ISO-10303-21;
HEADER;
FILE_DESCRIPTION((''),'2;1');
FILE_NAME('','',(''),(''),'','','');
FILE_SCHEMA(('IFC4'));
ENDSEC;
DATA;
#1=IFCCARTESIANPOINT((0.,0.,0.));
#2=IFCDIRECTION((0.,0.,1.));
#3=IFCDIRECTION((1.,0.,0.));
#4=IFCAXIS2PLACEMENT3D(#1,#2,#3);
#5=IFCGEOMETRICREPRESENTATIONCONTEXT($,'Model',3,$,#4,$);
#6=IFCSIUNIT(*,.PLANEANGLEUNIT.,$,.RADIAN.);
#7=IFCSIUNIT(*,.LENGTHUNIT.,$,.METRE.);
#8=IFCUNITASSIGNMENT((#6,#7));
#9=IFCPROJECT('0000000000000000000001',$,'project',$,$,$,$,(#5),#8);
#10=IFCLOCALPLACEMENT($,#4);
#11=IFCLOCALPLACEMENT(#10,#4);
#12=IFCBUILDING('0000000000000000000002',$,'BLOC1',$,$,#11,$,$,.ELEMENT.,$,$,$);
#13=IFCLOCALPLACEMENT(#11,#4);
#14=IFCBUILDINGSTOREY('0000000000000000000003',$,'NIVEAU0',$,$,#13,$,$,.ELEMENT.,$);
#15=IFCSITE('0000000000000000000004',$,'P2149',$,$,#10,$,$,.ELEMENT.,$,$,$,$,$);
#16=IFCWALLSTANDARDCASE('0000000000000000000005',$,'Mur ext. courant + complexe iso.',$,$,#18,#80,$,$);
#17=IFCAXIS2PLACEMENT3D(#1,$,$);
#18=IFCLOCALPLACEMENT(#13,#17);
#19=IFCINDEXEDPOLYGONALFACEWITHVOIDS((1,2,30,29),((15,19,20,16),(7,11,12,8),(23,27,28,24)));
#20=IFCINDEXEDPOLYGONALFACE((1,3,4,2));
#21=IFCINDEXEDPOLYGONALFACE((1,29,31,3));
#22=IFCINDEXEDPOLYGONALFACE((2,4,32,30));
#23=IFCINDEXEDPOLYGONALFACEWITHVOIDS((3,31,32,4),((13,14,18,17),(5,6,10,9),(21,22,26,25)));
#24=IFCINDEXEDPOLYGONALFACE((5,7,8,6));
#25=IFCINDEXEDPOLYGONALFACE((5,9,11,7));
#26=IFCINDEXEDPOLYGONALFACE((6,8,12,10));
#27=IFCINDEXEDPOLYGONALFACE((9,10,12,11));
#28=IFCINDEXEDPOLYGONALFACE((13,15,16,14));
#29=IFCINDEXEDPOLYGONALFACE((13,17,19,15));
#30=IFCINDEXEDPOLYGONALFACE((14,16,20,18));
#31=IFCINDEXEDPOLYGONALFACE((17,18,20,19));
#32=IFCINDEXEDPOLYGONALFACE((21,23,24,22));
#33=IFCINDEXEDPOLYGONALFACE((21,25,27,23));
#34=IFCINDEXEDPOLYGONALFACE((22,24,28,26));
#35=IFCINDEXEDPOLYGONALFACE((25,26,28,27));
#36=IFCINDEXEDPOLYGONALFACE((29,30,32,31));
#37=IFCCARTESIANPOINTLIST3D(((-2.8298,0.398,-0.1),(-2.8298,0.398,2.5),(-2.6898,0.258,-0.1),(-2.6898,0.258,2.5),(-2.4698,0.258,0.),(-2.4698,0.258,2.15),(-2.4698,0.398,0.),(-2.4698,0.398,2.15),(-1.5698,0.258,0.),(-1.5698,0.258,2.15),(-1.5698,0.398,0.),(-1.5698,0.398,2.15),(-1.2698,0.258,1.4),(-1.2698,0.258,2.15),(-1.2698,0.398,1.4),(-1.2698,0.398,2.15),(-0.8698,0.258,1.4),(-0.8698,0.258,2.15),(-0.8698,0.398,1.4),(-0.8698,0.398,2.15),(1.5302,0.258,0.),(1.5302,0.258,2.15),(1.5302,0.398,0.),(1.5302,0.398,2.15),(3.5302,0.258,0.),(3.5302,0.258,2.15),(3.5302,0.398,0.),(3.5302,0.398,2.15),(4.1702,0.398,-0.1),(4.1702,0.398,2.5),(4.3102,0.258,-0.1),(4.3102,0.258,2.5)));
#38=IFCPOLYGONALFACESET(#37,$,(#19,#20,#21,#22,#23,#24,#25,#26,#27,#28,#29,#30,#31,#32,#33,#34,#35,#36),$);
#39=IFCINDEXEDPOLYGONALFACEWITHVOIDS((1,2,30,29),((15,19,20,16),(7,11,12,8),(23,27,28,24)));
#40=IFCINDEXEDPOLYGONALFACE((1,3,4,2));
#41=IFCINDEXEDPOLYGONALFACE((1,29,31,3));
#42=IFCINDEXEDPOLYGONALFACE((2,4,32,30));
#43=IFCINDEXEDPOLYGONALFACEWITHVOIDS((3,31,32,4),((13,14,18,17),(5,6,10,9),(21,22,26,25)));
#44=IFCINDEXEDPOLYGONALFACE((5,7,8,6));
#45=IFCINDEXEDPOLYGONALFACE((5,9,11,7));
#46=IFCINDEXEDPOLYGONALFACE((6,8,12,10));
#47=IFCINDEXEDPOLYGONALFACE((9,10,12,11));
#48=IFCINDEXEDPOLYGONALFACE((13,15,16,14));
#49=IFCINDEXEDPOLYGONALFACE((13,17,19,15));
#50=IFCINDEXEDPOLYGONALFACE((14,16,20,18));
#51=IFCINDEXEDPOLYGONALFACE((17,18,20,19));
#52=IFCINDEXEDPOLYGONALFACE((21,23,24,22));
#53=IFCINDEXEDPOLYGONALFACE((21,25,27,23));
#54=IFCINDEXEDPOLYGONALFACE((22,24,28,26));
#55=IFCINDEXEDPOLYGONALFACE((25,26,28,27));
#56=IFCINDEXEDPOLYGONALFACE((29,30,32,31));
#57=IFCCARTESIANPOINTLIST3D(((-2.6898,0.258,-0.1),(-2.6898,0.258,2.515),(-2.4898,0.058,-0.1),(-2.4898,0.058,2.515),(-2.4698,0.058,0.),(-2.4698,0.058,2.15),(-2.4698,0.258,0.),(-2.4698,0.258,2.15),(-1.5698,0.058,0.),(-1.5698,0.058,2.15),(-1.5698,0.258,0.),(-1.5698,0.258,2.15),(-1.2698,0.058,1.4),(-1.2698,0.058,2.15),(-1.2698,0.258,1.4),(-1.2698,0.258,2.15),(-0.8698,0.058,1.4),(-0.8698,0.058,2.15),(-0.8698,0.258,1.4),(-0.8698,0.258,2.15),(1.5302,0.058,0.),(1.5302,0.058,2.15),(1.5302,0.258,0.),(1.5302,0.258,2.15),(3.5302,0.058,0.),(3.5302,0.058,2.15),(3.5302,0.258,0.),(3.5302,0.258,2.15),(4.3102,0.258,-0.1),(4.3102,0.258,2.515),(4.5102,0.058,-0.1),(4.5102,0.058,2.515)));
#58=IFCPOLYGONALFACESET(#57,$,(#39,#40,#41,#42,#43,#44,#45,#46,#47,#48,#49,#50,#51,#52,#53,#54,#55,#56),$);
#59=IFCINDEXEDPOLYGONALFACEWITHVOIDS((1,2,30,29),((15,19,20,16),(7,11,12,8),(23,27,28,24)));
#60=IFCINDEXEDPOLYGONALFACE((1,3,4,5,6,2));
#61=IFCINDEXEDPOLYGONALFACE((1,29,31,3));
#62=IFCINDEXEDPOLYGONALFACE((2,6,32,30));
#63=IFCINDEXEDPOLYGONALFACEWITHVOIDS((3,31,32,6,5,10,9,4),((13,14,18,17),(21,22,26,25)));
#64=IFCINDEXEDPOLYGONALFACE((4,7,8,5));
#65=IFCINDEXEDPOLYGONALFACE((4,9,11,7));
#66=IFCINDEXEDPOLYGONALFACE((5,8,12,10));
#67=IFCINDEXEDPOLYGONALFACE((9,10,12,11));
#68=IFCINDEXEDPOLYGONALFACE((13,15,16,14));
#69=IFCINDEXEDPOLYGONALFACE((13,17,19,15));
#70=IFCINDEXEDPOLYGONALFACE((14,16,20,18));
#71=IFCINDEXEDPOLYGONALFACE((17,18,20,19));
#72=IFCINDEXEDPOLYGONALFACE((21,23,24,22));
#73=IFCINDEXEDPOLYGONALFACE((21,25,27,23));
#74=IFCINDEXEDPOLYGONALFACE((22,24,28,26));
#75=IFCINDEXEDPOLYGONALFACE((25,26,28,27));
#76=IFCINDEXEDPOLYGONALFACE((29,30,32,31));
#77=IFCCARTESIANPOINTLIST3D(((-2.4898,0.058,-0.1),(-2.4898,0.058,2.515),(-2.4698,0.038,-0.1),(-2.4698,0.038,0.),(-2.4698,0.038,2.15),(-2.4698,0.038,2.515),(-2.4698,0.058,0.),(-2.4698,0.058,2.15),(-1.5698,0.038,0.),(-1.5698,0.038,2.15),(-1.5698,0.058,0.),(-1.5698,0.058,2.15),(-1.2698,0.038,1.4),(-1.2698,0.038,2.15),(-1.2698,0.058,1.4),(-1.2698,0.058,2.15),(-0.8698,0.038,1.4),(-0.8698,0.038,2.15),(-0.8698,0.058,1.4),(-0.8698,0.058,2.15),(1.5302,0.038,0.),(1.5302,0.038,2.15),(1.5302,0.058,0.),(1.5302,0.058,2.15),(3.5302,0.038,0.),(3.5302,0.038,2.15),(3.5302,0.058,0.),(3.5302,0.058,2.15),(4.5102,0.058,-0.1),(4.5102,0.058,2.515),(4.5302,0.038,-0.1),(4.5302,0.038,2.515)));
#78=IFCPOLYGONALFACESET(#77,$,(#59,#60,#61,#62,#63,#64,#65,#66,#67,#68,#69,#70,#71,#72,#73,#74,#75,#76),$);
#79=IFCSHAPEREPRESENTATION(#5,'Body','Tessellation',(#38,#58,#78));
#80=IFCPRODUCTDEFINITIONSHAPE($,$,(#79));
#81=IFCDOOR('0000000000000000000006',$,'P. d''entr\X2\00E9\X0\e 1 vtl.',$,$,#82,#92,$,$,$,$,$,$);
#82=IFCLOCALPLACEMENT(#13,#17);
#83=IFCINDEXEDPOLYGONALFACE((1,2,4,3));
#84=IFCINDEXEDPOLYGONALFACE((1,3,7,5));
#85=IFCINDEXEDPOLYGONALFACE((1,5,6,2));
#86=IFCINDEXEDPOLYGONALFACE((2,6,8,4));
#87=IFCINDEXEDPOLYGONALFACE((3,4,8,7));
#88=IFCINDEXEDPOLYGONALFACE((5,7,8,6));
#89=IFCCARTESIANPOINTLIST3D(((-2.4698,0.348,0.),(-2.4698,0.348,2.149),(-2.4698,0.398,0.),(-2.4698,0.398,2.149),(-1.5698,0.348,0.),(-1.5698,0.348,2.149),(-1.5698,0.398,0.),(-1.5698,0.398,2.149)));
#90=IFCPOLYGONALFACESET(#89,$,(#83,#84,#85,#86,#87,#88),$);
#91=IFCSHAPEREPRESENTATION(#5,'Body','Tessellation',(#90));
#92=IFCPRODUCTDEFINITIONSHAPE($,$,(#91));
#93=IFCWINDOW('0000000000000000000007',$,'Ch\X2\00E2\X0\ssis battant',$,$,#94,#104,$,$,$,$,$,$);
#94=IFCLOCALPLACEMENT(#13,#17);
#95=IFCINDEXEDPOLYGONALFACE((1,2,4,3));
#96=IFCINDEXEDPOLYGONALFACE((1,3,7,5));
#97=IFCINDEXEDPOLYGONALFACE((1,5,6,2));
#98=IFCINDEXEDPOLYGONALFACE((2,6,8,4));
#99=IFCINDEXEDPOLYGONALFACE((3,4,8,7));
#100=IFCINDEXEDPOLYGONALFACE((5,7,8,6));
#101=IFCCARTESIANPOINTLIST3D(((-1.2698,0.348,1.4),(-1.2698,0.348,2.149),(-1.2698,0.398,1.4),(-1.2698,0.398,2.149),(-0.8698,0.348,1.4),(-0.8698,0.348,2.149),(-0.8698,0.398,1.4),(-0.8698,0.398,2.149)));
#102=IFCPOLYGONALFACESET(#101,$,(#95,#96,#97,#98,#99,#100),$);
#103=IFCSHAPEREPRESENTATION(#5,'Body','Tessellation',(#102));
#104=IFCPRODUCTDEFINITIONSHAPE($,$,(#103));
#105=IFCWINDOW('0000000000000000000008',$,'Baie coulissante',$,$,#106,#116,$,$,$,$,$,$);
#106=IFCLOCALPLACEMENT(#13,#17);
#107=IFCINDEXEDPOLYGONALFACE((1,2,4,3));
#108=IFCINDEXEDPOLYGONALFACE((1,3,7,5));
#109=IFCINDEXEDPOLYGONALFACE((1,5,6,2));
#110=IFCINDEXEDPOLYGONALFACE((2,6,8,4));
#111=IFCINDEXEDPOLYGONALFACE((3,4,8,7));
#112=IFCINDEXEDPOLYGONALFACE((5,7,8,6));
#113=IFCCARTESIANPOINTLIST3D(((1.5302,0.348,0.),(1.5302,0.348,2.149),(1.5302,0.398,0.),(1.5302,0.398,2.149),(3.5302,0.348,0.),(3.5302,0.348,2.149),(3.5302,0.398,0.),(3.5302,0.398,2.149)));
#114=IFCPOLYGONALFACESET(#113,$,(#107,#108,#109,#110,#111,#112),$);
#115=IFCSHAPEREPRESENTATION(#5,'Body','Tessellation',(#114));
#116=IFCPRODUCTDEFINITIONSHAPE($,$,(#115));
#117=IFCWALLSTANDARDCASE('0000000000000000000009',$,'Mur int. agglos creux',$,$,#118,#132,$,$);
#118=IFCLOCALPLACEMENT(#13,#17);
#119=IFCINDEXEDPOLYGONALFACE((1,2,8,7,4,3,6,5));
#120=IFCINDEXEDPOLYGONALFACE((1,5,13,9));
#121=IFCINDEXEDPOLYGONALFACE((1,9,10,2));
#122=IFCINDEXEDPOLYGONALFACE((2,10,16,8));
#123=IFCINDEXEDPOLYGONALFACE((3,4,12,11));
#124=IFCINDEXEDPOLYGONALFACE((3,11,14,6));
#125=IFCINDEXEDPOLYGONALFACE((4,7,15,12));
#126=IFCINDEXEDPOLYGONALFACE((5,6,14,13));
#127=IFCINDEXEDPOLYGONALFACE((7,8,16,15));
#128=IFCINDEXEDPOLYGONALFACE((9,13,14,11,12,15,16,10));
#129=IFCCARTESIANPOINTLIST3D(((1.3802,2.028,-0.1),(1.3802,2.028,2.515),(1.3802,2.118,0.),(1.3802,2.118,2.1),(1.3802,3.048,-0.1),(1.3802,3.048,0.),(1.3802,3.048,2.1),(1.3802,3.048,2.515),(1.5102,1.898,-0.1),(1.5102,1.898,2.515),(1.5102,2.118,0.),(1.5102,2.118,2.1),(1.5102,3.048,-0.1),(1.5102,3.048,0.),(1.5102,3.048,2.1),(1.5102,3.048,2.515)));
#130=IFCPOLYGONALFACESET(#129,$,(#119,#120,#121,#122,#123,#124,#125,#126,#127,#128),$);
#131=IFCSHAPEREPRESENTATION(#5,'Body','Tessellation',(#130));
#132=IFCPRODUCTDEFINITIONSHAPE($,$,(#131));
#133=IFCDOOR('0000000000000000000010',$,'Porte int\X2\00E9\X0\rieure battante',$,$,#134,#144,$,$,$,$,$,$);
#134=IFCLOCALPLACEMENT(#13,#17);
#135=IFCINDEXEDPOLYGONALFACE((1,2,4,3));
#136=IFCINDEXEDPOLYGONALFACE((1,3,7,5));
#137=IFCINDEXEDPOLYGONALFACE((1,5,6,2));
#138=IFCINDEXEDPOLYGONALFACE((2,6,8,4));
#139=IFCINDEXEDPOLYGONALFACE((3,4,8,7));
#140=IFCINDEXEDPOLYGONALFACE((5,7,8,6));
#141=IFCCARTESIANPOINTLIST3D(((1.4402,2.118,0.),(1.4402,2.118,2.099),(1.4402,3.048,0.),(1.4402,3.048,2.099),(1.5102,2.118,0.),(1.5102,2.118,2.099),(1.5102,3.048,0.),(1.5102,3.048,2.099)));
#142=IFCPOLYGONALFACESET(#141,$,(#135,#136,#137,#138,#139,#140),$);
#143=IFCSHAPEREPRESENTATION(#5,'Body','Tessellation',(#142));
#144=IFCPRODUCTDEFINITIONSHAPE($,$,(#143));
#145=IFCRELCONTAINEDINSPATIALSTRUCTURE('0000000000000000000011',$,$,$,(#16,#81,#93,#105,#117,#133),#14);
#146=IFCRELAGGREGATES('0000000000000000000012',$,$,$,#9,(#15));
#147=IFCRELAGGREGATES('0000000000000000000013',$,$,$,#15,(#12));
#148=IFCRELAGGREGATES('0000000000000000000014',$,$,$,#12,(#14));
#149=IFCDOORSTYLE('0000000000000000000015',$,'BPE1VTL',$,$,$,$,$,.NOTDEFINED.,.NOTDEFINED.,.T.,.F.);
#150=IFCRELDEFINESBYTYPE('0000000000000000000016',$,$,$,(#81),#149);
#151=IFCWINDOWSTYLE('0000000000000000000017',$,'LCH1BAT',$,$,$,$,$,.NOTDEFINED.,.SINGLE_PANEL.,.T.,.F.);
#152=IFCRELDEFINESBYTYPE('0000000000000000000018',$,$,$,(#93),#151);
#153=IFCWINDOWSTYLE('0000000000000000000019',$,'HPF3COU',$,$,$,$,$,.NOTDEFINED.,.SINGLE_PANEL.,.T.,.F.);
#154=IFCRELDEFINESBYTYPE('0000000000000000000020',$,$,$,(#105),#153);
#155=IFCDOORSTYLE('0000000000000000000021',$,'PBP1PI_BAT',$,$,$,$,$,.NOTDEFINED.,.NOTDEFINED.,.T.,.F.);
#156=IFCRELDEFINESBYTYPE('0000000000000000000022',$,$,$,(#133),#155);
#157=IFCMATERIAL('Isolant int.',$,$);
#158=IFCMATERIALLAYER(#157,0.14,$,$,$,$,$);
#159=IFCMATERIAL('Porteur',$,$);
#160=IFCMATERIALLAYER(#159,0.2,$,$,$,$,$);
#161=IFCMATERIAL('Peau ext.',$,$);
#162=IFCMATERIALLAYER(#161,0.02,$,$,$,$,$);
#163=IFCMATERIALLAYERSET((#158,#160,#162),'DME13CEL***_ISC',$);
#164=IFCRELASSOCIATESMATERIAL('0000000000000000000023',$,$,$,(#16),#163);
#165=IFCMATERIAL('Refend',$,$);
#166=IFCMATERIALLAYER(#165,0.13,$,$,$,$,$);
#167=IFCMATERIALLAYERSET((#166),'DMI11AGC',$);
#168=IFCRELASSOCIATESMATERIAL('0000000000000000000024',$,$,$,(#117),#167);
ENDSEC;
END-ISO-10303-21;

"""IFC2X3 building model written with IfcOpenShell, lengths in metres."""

from ifc_helpers import new_model, si_unit, point, frame, frame_2d, origin_with_axes, place, context, project, spatial, line_curve, trimmed, segment, composite_curve, rectangle, outline, extrude, clip, bounded_halfspace, material, layer, layer_set, layer_usage, type_object, element, fill, save


model = new_model("IFC2X3")

# Units and contexts
model_context = context("Model", 3, world=origin_with_axes())
ifc_project = project(units=[si_unit("PLANEANGLEUNIT", "RADIAN"), si_unit("LENGTHUNIT", "METRE")], contexts=[model_context])

# Site, building, storey
site_placement = place(None, origin_with_axes())
site = spatial("IfcSite", under=ifc_project, at=site_placement, Name="P2149", CompositionType="ELEMENT")
building_placement = place(site_placement, origin_with_axes())
building = spatial("IfcBuilding", under=site, at=building_placement, Name="BLOC1", CompositionType="ELEMENT")
storey_placement = place(building_placement, origin_with_axes())
storey = spatial("IfcBuildingStorey", under=building, at=storey_placement, Name="NIVEAU0", CompositionType="ELEMENT")

# Shared definitions
ifc_material_1 = material(Name="Isolant int.")
ifc_layer_1 = layer(ifc_material_1, 0.14)
ifc_material_2 = material(Name="Porteur")
ifc_layer_2 = layer(ifc_material_2, 0.2)
ifc_material_3 = material(Name="Peau ext.")
ifc_layer_3 = layer(ifc_material_3, 0.02)
ifc_layer_set_1 = layer_set([ifc_layer_1, ifc_layer_2, ifc_layer_3], Name="DME13CEL***_ISC")
ifc_layer_usage_1 = layer_usage(ifc_layer_set_1, "AXIS2", "POSITIVE", 0.0)

# Wall, openings, door, windows
wall_1_placement = place(storey_placement, frame((4.1702, 0.398, -0.1), z_axis=(0.0, 0.0, 1.0), x_axis=(-1.0, 0.0, 0.0)))
wall_1 = element("IfcWallStandardCase", 1, at=wall_1_placement, inside=storey, material=ifc_layer_usage_1, Name="Mur ext. courant + complexe iso.", context=model_context, shape_type="Clipping", body=[
    clip(extrude(outline(composite_curve([segment(trimmed(line_curve((0.0, 0.0), (1.0, 0.0), 7.0), [point((0.0, 0.0))], [point((7.0, 0.0))], True, "CARTESIAN"), True, "CONTINUOUS"), segment(trimmed(line_curve((7.0, 0.0), (-0.707107, 0.707107), 0.19799), [point((7.0, 0.0))], [point((6.86, 0.14))], True, "CARTESIAN"), True, "CONTINUOUS"), segment(trimmed(line_curve((6.86, 0.14), (-1.0, 0.0), 7.0), [point((6.86, 0.14))], [point((-0.14, 0.14))], True, "CARTESIAN"), True, "CONTINUOUS"), segment(trimmed(line_curve((-0.14, 0.14), (0.707107, -0.707107), 0.19799), [point((-0.14, 0.14))], [point((0.0, 0.0))], True, "CARTESIAN"), True, "CONTINUOUS")], self_intersect=False)), origin_with_axes(), (0.0, 0.0, 1.0), 2.615), bounded_halfspace(frame((0.0, 0.0, 2.6), z_axis=(0.0, 0.0, 1.0), x_axis=(0.0, 1.0, 0.0)), False, frame((0.0, 0.0, 2.6), z_axis=(0.0, 0.0, 1.0), x_axis=(1.0, 0.0, 0.0)), composite_curve([segment(trimmed(line_curve((0.0, 0.0), (1.0, 0.0), 7.0), [point((0.0, 0.0))], [point((7.0, 0.0))], True, "CARTESIAN"), True, "CONTINUOUS"), segment(trimmed(line_curve((7.0, 0.0), (-0.707107, 0.707107), 0.19799), [point((7.0, 0.0))], [point((6.86, 0.14))], True, "CARTESIAN"), True, "CONTINUOUS"), segment(trimmed(line_curve((6.86, 0.14), (-1.0, 0.0), 7.0), [point((6.86, 0.14))], [point((-0.14, 0.14))], True, "CARTESIAN"), True, "CONTINUOUS"), segment(trimmed(line_curve((-0.14, 0.14), (0.707107, -0.707107), 0.19799), [point((-0.14, 0.14))], [point((0.0, 0.0))], True, "CARTESIAN"), True, "CONTINUOUS")], self_intersect=False))),
    extrude(outline(composite_curve([segment(trimmed(line_curve((-0.14, 0.14), (1.0, 0.0), 7.0), [point((-0.14, 0.14))], [point((6.86, 0.14))], True, "CARTESIAN"), True, "CONTINUOUS"), segment(trimmed(line_curve((6.86, 0.14), (-0.707107, 0.707107), 0.282843), [point((6.86, 0.14))], [point((6.66, 0.34))], True, "CARTESIAN"), True, "CONTINUOUS"), segment(trimmed(line_curve((6.66, 0.34), (-1.0, 0.0), 7.0), [point((6.66, 0.34))], [point((-0.34, 0.34))], True, "CARTESIAN"), True, "CONTINUOUS"), segment(trimmed(line_curve((-0.34, 0.34), (0.707107, -0.707107), 0.282843), [point((-0.34, 0.34))], [point((-0.14, 0.14))], True, "CARTESIAN"), True, "CONTINUOUS")], self_intersect=False)), origin_with_axes(), (0.0, 0.0, 1.0), 2.615),
    extrude(outline(composite_curve([segment(trimmed(line_curve((-0.34, 0.34), (1.0, 0.0), 7.0), [point((-0.34, 0.34))], [point((6.66, 0.34))], True, "CARTESIAN"), True, "CONTINUOUS"), segment(trimmed(line_curve((6.66, 0.34), (-0.707107, 0.707107), 0.028284), [point((6.66, 0.34))], [point((6.64, 0.36))], True, "CARTESIAN"), True, "CONTINUOUS"), segment(trimmed(line_curve((6.64, 0.36), (-1.0, 0.0), 7.0), [point((6.64, 0.36))], [point((-0.36, 0.36))], True, "CARTESIAN"), True, "CONTINUOUS"), segment(trimmed(line_curve((-0.36, 0.36), (0.707107, -0.707107), 0.028284), [point((-0.36, 0.36))], [point((-0.34, 0.34))], True, "CARTESIAN"), True, "CONTINUOUS")], self_intersect=False)), origin_with_axes(), (0.0, 0.0, 1.0), 2.615),
])
opening_1_placement = place(wall_1_placement, frame((6.64, 0.0, 0.1), z_axis=(0.0, 1.0, 0.0), x_axis=(-1.0, 0.0, 0.0)))
opening_1 = element("IfcOpeningElement", 2, at=opening_1_placement, cuts=wall_1, context=model_context, shape_type="SweptSolid", body=[
    extrude(rectangle(XDim=0.9, YDim=2.15, at=frame_2d((0.45, 1.075), x_axis=(1.0, 0.0))), origin_with_axes(), (0.0, 0.0, 1.0), 0.36),
])
opening_2_placement = place(wall_1_placement, frame((5.04, 0.0, 1.5), z_axis=(0.0, -1.0, 0.0), x_axis=(1.0, 0.0, 0.0)))
opening_2 = element("IfcOpeningElement", 3, at=opening_2_placement, cuts=wall_1, context=model_context, shape_type="SweptSolid", body=[
    extrude(rectangle(XDim=0.4, YDim=0.75, at=frame_2d((0.2, 0.375), x_axis=(1.0, 0.0))), origin_with_axes(), (0.0, 0.0, -1.0), 0.36),
])
opening_3_placement = place(wall_1_placement, frame((2.64, 0.0, 0.1), z_axis=(0.0, 1.0, 0.0), x_axis=(-1.0, 0.0, 0.0)))
opening_3 = element("IfcOpeningElement", 4, at=opening_3_placement, cuts=wall_1, context=model_context, shape_type="SweptSolid", body=[
    extrude(rectangle(XDim=2.0, YDim=2.15, at=frame_2d((1.0, 1.075), x_axis=(1.0, 0.0))), origin_with_axes(), (0.0, 0.0, 1.0), 0.36),
])
door_style_1 = type_object("IfcDoorStyle", Name="BPE1VTL", ConstructionType="NOTDEFINED", OperationType="NOTDEFINED", ParameterTakesPrecedence=True, Sizeable=False)
door_1_placement = place(opening_1_placement, origin_with_axes())
door_1 = element("IfcDoor", 5, at=door_1_placement, inside=storey, type_object=door_style_1, Name="P. d'entrée 1 vtl.", context=model_context, shape_type="SweptSolid", body=[
    extrude(rectangle(XDim=0.9, YDim=2.149, at=frame_2d((0.45, 1.0745), x_axis=(1.0, 0.0))), origin_with_axes(), (0.0, 0.0, 1.0), 0.05),
])
fill(opening_1, door_1)
window_style_1 = type_object("IfcWindowStyle", Name="LCH1BAT", ConstructionType="NOTDEFINED", OperationType="SINGLE_PANEL", ParameterTakesPrecedence=True, Sizeable=False)
window_1_placement = place(opening_2_placement, origin_with_axes())
window_1 = element("IfcWindow", 6, at=window_1_placement, inside=storey, type_object=window_style_1, Name="Châssis battant", context=model_context, shape_type="SweptSolid", body=[
    extrude(rectangle(XDim=0.4, YDim=0.749, at=frame_2d((0.2, 0.3745), x_axis=(1.0, 0.0))), origin_with_axes(), (0.0, 0.0, -1.0), 0.05),
])
fill(opening_2, window_1)
window_style_2 = type_object("IfcWindowStyle", Name="HPF3COU", ConstructionType="NOTDEFINED", OperationType="SINGLE_PANEL", ParameterTakesPrecedence=True, Sizeable=False)
window_2_placement = place(opening_3_placement, origin_with_axes())
window_2 = element("IfcWindow", 7, at=window_2_placement, inside=storey, type_object=window_style_2, Name="Baie coulissante", context=model_context, shape_type="SweptSolid", body=[
    extrude(rectangle(XDim=2.0, YDim=2.149, at=frame_2d((1.0, 1.0745), x_axis=(1.0, 0.0))), origin_with_axes(), (0.0, 0.0, 1.0), 0.05),
])
fill(opening_3, window_2)

# Wall, opening, door
ifc_material_4 = material(Name="Refend")
ifc_layer_4 = layer(ifc_material_4, 0.13)
ifc_layer_set_2 = layer_set([ifc_layer_4], Name="DMI11AGC")
ifc_layer_usage_2 = layer_usage(ifc_layer_set_2, "AXIS2", "POSITIVE", 0.0)
wall_2_placement = place(storey_placement, frame((1.3802, 3.048, -0.1), z_axis=(0.0, 0.0, 1.0), x_axis=(0.0, -1.0, 0.0)))
wall_2 = element("IfcWallStandardCase", 8, at=wall_2_placement, inside=storey, material=ifc_layer_usage_2, Name="Mur int. agglos creux", context=model_context, shape_type="SweptSolid", body=[
    extrude(outline(composite_curve([segment(trimmed(line_curve((0.0, 0.0), (1.0, 0.0), 1.02), [point((0.0, 0.0))], [point((1.02, 0.0))], True, "CARTESIAN"), True, "CONTINUOUS"), segment(trimmed(line_curve((1.02, 0.0), (0.707107, 0.707107), 0.183848), [point((1.02, 0.0))], [point((1.15, 0.13))], True, "CARTESIAN"), True, "CONTINUOUS"), segment(trimmed(line_curve((1.15, 0.13), (-1.0, 0.0), 1.15), [point((1.15, 0.13))], [point((0.0, 0.13))], True, "CARTESIAN"), True, "CONTINUOUS"), segment(trimmed(line_curve((0.0, 0.13), (0.0, -1.0), 0.13), [point((0.0, 0.13))], [point((0.0, 0.0))], True, "CARTESIAN"), True, "CONTINUOUS")], self_intersect=False)), origin_with_axes(), (0.0, 0.0, 1.0), 2.615),
])
opening_4_placement = place(wall_2_placement, frame((0.93, 0.13, 0.1), z_axis=(0.0, 1.0, 0.0), x_axis=(-1.0, 0.0, 0.0)))
opening_4 = element("IfcOpeningElement", 9, at=opening_4_placement, cuts=wall_2, context=model_context, shape_type="SweptSolid", body=[
    extrude(rectangle(XDim=0.93, YDim=2.1, at=frame_2d((0.465, 1.05), x_axis=(1.0, 0.0))), origin_with_axes(), (0.0, 0.0, -1.0), 0.13),
])
door_style_2 = type_object("IfcDoorStyle", Name="PBP1PI_BAT", ConstructionType="NOTDEFINED", OperationType="NOTDEFINED", ParameterTakesPrecedence=True, Sizeable=False)
door_2_placement = place(opening_4_placement, origin_with_axes())
door_2 = element("IfcDoor", 10, at=door_2_placement, inside=storey, type_object=door_style_2, Name="Porte intérieure battante", context=model_context, shape_type="SweptSolid", body=[
    extrude(rectangle(XDim=0.93, YDim=2.099, at=frame_2d((0.465, 1.0495), x_axis=(1.0, 0.0))), origin_with_axes(), (0.0, 0.0, -1.0), 0.07),
])
fill(opening_4, door_2)

save(model, "model.ifc")
